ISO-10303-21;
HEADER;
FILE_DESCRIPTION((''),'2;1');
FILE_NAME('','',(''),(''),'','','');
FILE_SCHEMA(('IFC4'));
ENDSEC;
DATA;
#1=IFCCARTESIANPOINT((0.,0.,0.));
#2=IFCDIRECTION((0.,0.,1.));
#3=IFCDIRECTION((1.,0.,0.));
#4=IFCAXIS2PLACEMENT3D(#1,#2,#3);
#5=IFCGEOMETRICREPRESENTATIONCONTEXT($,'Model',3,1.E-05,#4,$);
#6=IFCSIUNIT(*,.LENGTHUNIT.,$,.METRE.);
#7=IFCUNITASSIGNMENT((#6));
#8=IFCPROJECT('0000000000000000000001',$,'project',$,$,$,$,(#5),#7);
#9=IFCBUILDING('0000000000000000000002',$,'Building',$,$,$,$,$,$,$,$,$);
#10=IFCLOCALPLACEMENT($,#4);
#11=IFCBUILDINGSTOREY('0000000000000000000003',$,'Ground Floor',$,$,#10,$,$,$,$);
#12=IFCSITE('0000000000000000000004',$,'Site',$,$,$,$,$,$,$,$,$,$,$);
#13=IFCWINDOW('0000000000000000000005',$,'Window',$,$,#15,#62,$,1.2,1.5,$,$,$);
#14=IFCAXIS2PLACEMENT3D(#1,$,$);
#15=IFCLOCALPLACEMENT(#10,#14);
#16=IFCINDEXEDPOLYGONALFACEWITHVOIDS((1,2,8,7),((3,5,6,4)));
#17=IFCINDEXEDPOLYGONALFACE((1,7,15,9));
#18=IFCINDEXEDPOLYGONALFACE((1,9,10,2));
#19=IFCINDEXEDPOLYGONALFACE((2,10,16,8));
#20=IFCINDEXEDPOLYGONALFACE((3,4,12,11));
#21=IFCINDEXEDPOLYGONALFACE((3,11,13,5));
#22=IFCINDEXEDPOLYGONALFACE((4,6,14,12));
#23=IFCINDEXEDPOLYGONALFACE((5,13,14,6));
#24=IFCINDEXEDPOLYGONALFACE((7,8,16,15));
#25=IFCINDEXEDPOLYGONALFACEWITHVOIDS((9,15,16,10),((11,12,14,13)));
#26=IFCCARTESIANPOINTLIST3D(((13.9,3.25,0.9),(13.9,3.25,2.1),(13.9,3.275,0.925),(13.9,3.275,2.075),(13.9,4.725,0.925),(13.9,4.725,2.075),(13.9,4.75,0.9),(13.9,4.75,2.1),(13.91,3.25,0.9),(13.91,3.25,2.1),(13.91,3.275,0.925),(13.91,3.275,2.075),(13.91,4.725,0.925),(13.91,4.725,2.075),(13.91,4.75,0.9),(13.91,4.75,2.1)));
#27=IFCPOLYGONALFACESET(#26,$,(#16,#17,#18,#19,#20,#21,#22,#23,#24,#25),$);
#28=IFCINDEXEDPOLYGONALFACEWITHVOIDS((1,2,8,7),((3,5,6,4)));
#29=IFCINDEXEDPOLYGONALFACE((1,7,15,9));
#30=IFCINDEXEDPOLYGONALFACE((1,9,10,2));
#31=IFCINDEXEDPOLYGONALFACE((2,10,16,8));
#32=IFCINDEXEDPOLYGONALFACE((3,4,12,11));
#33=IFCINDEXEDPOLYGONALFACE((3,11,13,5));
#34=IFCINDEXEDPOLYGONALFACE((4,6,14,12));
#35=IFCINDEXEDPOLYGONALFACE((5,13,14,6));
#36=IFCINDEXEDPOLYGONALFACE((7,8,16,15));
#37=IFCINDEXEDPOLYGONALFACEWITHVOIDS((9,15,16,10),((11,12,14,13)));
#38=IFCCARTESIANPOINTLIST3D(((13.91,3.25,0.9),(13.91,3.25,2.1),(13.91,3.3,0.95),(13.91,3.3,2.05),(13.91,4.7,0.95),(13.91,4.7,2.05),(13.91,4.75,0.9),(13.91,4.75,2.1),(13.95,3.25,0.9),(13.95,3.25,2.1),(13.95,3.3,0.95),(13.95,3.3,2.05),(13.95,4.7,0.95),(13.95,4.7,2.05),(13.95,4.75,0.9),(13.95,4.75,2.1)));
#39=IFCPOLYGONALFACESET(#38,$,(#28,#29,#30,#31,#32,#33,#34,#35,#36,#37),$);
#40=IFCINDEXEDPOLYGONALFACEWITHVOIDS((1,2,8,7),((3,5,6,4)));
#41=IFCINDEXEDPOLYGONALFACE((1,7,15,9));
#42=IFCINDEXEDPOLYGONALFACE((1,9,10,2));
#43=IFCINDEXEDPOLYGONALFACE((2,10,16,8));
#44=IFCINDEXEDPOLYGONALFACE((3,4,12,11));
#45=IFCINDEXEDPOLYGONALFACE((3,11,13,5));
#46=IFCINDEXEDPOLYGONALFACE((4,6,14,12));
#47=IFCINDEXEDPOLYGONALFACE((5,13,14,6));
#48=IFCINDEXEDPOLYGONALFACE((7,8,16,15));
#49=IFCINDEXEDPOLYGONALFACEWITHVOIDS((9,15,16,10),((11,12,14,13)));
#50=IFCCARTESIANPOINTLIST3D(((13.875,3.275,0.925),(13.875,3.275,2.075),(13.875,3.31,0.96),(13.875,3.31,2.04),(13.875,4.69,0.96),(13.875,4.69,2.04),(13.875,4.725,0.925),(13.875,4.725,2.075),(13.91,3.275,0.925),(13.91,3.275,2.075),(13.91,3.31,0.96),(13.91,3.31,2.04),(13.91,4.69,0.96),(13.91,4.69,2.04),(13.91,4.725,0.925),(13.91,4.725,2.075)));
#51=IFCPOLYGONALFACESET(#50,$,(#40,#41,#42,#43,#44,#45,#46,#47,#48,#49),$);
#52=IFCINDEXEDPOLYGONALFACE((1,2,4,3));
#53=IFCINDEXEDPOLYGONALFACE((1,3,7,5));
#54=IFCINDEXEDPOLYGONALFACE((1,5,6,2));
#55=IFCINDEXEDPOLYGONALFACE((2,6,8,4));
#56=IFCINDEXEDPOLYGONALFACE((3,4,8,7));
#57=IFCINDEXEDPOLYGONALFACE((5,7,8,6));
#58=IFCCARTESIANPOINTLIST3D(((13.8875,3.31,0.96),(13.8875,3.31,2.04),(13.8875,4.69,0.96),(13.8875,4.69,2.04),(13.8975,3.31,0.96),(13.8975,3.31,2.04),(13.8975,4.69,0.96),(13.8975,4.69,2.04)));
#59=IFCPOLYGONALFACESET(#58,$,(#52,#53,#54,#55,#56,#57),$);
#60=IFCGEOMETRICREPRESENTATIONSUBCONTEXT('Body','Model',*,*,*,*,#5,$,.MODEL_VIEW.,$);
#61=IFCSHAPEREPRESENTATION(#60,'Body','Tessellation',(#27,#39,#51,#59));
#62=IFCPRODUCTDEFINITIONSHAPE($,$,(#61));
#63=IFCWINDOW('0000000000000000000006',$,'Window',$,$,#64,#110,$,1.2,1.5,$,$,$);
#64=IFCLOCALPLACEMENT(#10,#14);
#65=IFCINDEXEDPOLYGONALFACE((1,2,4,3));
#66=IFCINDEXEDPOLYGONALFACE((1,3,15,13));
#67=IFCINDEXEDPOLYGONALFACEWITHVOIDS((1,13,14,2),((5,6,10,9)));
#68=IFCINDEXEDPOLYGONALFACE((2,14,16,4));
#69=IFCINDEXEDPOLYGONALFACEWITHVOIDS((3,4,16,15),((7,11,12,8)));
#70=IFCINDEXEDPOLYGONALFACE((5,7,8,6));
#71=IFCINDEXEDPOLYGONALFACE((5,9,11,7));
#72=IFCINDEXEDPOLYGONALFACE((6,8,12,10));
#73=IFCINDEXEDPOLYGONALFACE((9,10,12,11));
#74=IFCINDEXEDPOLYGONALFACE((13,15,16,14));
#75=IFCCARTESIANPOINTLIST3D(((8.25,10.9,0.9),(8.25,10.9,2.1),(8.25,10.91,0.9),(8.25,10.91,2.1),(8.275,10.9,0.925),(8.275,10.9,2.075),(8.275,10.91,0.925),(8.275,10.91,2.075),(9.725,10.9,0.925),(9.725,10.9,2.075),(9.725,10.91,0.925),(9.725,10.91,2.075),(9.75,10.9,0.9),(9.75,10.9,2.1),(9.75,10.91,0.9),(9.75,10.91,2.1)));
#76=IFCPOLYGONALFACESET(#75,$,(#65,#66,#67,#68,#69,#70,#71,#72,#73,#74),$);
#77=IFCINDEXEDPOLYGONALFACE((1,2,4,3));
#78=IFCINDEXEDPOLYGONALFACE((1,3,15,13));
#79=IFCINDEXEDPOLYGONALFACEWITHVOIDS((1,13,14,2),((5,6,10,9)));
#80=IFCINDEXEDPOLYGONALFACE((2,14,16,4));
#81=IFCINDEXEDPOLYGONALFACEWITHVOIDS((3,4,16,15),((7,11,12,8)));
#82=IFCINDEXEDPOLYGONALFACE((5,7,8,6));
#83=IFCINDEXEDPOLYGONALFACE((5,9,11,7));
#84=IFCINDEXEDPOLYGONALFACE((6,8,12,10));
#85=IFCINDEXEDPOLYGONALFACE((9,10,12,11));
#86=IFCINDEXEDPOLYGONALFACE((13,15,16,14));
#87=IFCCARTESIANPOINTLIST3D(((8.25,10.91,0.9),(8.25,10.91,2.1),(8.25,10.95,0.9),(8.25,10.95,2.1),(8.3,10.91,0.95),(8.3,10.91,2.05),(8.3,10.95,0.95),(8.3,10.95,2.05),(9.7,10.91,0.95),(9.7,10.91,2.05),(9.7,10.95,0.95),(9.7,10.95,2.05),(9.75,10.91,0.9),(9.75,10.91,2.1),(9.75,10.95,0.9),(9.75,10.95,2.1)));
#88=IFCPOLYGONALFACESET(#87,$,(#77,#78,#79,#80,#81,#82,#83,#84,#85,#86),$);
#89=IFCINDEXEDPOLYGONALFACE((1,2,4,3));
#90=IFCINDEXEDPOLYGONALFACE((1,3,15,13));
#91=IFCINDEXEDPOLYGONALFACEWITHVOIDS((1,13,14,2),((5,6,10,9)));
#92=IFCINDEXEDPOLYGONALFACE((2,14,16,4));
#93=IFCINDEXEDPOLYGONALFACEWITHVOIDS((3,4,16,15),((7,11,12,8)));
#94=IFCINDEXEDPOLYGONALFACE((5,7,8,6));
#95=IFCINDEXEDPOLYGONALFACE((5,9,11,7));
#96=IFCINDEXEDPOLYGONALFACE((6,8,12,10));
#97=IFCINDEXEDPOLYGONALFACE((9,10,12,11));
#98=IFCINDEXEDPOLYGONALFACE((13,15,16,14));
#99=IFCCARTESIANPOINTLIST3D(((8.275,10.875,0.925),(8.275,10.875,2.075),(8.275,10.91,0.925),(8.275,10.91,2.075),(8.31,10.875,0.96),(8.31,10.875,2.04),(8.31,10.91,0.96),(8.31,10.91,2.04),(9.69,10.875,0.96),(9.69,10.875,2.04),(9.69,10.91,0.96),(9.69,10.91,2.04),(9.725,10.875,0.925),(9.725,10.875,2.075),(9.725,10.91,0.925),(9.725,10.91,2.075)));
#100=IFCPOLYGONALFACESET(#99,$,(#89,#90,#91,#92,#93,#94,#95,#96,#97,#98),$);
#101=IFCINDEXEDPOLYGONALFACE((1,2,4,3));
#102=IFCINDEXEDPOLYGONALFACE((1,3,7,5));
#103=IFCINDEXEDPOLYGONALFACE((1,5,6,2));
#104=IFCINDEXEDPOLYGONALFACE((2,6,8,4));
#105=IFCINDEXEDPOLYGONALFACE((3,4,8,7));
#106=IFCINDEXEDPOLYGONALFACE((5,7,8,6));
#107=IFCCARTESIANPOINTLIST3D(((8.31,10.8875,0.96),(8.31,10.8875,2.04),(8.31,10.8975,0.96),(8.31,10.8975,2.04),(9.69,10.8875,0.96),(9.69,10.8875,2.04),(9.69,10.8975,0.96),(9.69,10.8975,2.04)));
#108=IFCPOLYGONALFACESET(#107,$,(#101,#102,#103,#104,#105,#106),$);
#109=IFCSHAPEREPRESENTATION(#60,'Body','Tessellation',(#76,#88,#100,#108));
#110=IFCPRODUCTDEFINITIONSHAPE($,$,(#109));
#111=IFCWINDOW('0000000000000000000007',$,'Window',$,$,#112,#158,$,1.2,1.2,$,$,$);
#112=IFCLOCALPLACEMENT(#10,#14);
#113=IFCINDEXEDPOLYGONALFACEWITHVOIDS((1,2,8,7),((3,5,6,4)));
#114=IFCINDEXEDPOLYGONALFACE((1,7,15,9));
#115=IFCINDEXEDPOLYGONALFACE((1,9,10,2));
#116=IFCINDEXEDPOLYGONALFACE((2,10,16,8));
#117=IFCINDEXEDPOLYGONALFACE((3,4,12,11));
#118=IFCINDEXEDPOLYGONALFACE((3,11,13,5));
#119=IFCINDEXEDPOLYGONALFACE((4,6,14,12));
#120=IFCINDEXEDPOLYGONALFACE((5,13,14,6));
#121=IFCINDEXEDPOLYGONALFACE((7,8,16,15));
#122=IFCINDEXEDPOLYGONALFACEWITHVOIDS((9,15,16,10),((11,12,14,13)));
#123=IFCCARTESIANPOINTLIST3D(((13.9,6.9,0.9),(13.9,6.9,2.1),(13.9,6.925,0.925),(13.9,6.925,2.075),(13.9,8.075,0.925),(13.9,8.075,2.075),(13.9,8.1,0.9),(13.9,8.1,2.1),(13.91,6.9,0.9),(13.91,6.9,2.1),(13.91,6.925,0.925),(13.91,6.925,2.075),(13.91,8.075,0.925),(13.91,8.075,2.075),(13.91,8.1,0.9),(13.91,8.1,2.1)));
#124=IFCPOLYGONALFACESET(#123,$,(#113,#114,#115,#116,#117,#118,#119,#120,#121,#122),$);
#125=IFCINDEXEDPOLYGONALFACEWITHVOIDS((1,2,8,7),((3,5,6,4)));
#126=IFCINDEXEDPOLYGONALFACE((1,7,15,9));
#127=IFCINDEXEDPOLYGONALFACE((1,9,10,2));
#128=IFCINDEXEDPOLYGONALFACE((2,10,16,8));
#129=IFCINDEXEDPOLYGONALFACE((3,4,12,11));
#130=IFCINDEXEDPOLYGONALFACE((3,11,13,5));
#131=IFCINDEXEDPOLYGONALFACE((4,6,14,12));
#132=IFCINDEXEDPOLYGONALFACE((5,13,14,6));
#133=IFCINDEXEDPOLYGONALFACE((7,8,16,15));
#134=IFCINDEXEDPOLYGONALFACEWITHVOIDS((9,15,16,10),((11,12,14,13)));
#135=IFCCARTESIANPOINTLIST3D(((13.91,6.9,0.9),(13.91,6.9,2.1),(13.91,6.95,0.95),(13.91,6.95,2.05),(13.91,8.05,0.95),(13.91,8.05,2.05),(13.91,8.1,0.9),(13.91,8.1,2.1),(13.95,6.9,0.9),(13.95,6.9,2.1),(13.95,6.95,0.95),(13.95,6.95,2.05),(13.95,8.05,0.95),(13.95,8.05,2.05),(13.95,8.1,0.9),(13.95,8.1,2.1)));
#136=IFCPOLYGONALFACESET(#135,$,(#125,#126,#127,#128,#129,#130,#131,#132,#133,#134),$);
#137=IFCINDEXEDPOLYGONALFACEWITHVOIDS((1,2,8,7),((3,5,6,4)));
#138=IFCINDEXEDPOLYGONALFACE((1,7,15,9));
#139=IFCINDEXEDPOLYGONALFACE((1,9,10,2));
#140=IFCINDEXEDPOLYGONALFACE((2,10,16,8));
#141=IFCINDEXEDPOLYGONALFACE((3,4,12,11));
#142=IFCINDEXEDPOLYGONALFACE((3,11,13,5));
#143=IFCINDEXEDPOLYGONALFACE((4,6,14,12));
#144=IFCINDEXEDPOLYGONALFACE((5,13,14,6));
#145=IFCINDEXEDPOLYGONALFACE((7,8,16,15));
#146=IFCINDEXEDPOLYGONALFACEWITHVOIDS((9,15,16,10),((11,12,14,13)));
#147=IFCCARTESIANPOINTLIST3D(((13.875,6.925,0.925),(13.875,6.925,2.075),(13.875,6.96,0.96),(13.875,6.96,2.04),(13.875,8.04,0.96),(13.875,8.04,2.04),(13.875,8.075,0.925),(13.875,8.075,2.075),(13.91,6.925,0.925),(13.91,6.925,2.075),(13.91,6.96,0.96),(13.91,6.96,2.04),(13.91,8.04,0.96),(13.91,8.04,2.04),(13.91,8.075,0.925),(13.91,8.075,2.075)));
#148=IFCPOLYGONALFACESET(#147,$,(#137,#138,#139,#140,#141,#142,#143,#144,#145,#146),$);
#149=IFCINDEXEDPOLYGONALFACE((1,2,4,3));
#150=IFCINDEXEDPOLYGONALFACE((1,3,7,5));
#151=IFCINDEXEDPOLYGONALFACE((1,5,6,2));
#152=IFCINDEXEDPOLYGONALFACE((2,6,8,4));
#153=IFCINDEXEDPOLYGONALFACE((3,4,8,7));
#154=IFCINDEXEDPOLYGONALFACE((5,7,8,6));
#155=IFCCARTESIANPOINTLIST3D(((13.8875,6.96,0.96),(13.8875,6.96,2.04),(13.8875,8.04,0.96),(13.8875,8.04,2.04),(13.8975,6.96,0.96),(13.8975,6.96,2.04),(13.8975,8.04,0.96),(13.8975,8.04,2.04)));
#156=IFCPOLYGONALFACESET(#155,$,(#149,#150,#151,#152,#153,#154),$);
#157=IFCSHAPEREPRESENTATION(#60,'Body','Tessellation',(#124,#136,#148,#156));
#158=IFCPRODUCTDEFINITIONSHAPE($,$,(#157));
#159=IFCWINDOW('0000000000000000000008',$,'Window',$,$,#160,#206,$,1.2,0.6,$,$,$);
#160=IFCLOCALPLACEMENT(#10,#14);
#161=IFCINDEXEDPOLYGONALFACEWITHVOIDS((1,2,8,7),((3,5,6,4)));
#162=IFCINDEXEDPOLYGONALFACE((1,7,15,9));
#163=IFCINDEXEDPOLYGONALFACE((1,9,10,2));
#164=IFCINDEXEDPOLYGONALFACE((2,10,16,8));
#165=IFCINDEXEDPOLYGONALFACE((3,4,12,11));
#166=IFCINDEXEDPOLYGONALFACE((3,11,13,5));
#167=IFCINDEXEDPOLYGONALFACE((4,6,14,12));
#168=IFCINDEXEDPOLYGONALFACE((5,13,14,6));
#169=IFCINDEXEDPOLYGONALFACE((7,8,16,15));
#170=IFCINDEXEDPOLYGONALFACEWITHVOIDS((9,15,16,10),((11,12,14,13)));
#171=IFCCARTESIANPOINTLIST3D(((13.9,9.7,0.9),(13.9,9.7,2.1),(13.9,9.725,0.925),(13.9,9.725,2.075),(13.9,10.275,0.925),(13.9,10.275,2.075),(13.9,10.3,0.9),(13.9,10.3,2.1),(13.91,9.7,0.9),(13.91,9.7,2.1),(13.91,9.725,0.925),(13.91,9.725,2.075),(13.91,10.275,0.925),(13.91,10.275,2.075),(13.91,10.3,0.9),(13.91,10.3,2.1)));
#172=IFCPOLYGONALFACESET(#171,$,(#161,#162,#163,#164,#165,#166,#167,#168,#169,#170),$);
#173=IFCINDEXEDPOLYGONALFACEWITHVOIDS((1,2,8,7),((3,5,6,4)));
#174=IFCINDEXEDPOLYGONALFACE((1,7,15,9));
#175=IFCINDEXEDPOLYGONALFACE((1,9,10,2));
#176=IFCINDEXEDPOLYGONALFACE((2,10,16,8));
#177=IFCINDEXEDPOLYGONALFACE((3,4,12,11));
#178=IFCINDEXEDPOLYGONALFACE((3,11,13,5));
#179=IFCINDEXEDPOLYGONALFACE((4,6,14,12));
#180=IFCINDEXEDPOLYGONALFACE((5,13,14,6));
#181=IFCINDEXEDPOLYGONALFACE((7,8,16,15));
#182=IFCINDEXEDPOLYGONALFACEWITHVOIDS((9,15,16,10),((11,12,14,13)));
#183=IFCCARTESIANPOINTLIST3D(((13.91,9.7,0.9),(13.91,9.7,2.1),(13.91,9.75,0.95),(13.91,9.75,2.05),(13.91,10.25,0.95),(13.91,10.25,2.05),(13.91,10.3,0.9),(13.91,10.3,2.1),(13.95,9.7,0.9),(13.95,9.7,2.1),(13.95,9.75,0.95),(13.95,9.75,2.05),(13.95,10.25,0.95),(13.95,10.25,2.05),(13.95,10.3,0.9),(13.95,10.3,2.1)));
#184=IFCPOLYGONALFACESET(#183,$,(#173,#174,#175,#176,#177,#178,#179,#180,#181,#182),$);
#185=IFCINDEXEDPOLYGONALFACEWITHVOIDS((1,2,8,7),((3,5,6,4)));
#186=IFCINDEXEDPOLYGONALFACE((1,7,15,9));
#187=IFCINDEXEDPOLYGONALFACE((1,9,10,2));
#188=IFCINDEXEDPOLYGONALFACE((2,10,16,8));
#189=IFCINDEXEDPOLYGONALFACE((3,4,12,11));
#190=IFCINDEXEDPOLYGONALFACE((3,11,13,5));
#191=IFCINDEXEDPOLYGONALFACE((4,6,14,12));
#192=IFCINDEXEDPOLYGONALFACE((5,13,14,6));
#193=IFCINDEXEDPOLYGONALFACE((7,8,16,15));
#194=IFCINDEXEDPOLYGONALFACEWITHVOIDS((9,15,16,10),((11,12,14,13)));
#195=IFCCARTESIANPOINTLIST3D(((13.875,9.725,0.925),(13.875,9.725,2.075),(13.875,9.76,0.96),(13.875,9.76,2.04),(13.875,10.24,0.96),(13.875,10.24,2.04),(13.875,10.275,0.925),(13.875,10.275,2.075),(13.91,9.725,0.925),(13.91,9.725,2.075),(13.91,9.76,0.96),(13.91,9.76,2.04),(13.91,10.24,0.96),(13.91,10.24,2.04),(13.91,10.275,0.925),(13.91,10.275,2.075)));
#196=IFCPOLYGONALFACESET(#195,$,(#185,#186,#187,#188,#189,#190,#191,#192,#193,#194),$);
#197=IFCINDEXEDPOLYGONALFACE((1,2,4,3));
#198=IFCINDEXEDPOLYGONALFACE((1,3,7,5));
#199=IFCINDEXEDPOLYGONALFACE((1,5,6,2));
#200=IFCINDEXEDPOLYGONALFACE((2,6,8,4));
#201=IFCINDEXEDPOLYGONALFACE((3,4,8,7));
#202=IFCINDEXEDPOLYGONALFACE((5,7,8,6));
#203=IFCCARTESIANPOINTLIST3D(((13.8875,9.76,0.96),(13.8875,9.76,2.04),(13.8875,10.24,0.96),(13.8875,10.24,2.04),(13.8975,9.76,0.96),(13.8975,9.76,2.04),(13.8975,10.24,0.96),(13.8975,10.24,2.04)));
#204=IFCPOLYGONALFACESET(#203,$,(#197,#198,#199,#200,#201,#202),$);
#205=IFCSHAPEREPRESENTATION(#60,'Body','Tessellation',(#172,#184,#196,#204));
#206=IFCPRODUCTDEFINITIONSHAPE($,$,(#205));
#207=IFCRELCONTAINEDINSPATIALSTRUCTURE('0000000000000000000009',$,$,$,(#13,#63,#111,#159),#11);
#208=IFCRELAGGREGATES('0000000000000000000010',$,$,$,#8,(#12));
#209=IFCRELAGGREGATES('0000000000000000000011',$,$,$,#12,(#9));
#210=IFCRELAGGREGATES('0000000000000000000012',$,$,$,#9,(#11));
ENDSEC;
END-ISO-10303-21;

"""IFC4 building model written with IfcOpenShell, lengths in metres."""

from ifc_helpers import new_model, si_unit, frame, origin_with_axes, place, context, subcontext, project, spatial, line, indexed_curve, outline, extrude, element, save


model = new_model("IFC4")

# Units and contexts
model_context = context("Model", 3, precision=1e-05, world=origin_with_axes())
body_context = subcontext(model_context, "Body", "Model", "MODEL_VIEW")
ifc_project = project(units=[si_unit("LENGTHUNIT", "METRE")], contexts=[model_context])

# Site, building, storey
site = spatial("IfcSite", under=ifc_project, Name="Site")
building = spatial("IfcBuilding", under=site, Name="Building")
storey_placement = place(None, origin_with_axes())
storey = spatial("IfcBuildingStorey", under=building, at=storey_placement, Name="Ground Floor")

# Windows
for number, where, z_axis, x_axis, name in (
    (1, (14.0, 3.25, 0.9), (0.0, 0.0, 1.0), (0.0, 1.0, 0.0), "Window"),
    (2, (9.75, 11.0, 0.9), (0.0, 0.0, 1.0), (-1.0, 0.0, 0.0), "Window"),
):
    element("IfcWindow", number, at=place(storey_placement, frame(where, z_axis=z_axis, x_axis=x_axis)), inside=storey, Name=name, OverallHeight=1.2, OverallWidth=1.5, context=body_context, shape_type="SweptSolid", body=[
        extrude(outline(indexed_curve([(0.0, 0.0), (1.5, 0.0), (1.5, 1.2), (0.0, 1.2)], segments=[line(1, 2, 3, 4, 1)]), holes=[indexed_curve([(0.025, 0.025), (1.475, 0.025), (1.475, 1.175), (0.025, 1.175)], segments=[line(1, 2, 3, 4, 1)])]), frame((0.0, 0.09, 0.0), z_axis=(0.0, -1.0, 0.0), x_axis=(1.0, 0.0, 0.0)), (0.0, 0.0, -1.0), 0.01),
        extrude(outline(indexed_curve([(0.0, 0.0), (1.5, 0.0), (1.5, 1.2), (0.0, 1.2)], segments=[line(1, 2, 3, 4, 1)]), holes=[indexed_curve([(0.05, 0.05), (1.45, 0.05), (1.45, 1.15), (0.05, 1.15)], segments=[line(1, 2, 3, 4, 1)])]), frame((0.0, 0.05, 0.0), z_axis=(0.0, -1.0, 0.0), x_axis=(1.0, 0.0, 0.0)), (0.0, 0.0, -1.0), 0.04),
        extrude(outline(indexed_curve([(0.0, 0.0), (1.45, 0.0), (1.45, 1.15), (0.0, 1.15)], segments=[line(1, 2, 3, 4, 1)]), holes=[indexed_curve([(0.035, 0.035), (1.415, 0.035), (1.415, 1.115), (0.035, 1.115)], segments=[line(1, 2, 3, 4, 1)])]), frame((0.025, 0.09, 0.025), z_axis=(0.0, -1.0, 0.0), x_axis=(1.0, 0.0, 0.0)), (0.0, 0.0, -1.0), 0.035),
        extrude(outline(indexed_curve([(0.035, 0.035), (1.415, 0.035), (1.415, 1.115), (0.035, 1.115)], segments=[line(1, 2, 3, 4, 1)])), frame((0.025, 0.1025, 0.025), z_axis=(0.0, -1.0, 0.0), x_axis=(1.0, 0.0, 0.0)), (0.0, 0.0, -1.0), 0.01),
    ])
window_1_placement = place(storey_placement, frame((14.0, 6.9, 0.9), z_axis=(0.0, 0.0, 1.0), x_axis=(0.0, 1.0, 0.0)))
element("IfcWindow", 3, at=window_1_placement, inside=storey, Name="Window", OverallHeight=1.2, OverallWidth=1.2, context=body_context, shape_type="SweptSolid", body=[
    extrude(outline(indexed_curve([(0.0, 0.0), (1.2, 0.0), (1.2, 1.2), (0.0, 1.2)], segments=[line(1, 2, 3, 4, 1)]), holes=[indexed_curve([(0.025, 0.025), (1.175, 0.025), (1.175, 1.175), (0.025, 1.175)], segments=[line(1, 2, 3, 4, 1)])]), frame((0.0, 0.09, 0.0), z_axis=(0.0, -1.0, 0.0), x_axis=(1.0, 0.0, 0.0)), (0.0, 0.0, -1.0), 0.01),
    extrude(outline(indexed_curve([(0.0, 0.0), (1.2, 0.0), (1.2, 1.2), (0.0, 1.2)], segments=[line(1, 2, 3, 4, 1)]), holes=[indexed_curve([(0.05, 0.05), (1.15, 0.05), (1.15, 1.15), (0.05, 1.15)], segments=[line(1, 2, 3, 4, 1)])]), frame((0.0, 0.05, 0.0), z_axis=(0.0, -1.0, 0.0), x_axis=(1.0, 0.0, 0.0)), (0.0, 0.0, -1.0), 0.04),
    extrude(outline(indexed_curve([(0.0, 0.0), (1.15, 0.0), (1.15, 1.15), (0.0, 1.15)], segments=[line(1, 2, 3, 4, 1)]), holes=[indexed_curve([(0.035, 0.035), (1.115, 0.035), (1.115, 1.115), (0.035, 1.115)], segments=[line(1, 2, 3, 4, 1)])]), frame((0.025, 0.09, 0.025), z_axis=(0.0, -1.0, 0.0), x_axis=(1.0, 0.0, 0.0)), (0.0, 0.0, -1.0), 0.035),
    extrude(outline(indexed_curve([(0.035, 0.035), (1.115, 0.035), (1.115, 1.115), (0.035, 1.115)], segments=[line(1, 2, 3, 4, 1)])), frame((0.025, 0.1025, 0.025), z_axis=(0.0, -1.0, 0.0), x_axis=(1.0, 0.0, 0.0)), (0.0, 0.0, -1.0), 0.01),
])
window_2_placement = place(storey_placement, frame((14.0, 9.7, 0.9), z_axis=(0.0, 0.0, 1.0), x_axis=(0.0, 1.0, 0.0)))
element("IfcWindow", 4, at=window_2_placement, inside=storey, Name="Window", OverallHeight=1.2, OverallWidth=0.6, context=body_context, shape_type="SweptSolid", body=[
    extrude(outline(indexed_curve([(0.0, 0.0), (0.6, 0.0), (0.6, 1.2), (0.0, 1.2)], segments=[line(1, 2, 3, 4, 1)]), holes=[indexed_curve([(0.025, 0.025), (0.575, 0.025), (0.575, 1.175), (0.025, 1.175)], segments=[line(1, 2, 3, 4, 1)])]), frame((0.0, 0.09, 0.0), z_axis=(0.0, -1.0, 0.0), x_axis=(1.0, 0.0, 0.0)), (0.0, 0.0, -1.0), 0.01),
    extrude(outline(indexed_curve([(0.0, 0.0), (0.6, 0.0), (0.6, 1.2), (0.0, 1.2)], segments=[line(1, 2, 3, 4, 1)]), holes=[indexed_curve([(0.05, 0.05), (0.55, 0.05), (0.55, 1.15), (0.05, 1.15)], segments=[line(1, 2, 3, 4, 1)])]), frame((0.0, 0.05, 0.0), z_axis=(0.0, -1.0, 0.0), x_axis=(1.0, 0.0, 0.0)), (0.0, 0.0, -1.0), 0.04),
    extrude(outline(indexed_curve([(0.0, 0.0), (0.55, 0.0), (0.55, 1.15), (0.0, 1.15)], segments=[line(1, 2, 3, 4, 1)]), holes=[indexed_curve([(0.035, 0.035), (0.515, 0.035), (0.515, 1.115), (0.035, 1.115)], segments=[line(1, 2, 3, 4, 1)])]), frame((0.025, 0.09, 0.025), z_axis=(0.0, -1.0, 0.0), x_axis=(1.0, 0.0, 0.0)), (0.0, 0.0, -1.0), 0.035),
    extrude(outline(indexed_curve([(0.035, 0.035), (0.515, 0.035), (0.515, 1.115), (0.035, 1.115)], segments=[line(1, 2, 3, 4, 1)])), frame((0.025, 0.1025, 0.025), z_axis=(0.0, -1.0, 0.0), x_axis=(1.0, 0.0, 0.0)), (0.0, 0.0, -1.0), 0.01),
])

save(model, "model.ifc")
